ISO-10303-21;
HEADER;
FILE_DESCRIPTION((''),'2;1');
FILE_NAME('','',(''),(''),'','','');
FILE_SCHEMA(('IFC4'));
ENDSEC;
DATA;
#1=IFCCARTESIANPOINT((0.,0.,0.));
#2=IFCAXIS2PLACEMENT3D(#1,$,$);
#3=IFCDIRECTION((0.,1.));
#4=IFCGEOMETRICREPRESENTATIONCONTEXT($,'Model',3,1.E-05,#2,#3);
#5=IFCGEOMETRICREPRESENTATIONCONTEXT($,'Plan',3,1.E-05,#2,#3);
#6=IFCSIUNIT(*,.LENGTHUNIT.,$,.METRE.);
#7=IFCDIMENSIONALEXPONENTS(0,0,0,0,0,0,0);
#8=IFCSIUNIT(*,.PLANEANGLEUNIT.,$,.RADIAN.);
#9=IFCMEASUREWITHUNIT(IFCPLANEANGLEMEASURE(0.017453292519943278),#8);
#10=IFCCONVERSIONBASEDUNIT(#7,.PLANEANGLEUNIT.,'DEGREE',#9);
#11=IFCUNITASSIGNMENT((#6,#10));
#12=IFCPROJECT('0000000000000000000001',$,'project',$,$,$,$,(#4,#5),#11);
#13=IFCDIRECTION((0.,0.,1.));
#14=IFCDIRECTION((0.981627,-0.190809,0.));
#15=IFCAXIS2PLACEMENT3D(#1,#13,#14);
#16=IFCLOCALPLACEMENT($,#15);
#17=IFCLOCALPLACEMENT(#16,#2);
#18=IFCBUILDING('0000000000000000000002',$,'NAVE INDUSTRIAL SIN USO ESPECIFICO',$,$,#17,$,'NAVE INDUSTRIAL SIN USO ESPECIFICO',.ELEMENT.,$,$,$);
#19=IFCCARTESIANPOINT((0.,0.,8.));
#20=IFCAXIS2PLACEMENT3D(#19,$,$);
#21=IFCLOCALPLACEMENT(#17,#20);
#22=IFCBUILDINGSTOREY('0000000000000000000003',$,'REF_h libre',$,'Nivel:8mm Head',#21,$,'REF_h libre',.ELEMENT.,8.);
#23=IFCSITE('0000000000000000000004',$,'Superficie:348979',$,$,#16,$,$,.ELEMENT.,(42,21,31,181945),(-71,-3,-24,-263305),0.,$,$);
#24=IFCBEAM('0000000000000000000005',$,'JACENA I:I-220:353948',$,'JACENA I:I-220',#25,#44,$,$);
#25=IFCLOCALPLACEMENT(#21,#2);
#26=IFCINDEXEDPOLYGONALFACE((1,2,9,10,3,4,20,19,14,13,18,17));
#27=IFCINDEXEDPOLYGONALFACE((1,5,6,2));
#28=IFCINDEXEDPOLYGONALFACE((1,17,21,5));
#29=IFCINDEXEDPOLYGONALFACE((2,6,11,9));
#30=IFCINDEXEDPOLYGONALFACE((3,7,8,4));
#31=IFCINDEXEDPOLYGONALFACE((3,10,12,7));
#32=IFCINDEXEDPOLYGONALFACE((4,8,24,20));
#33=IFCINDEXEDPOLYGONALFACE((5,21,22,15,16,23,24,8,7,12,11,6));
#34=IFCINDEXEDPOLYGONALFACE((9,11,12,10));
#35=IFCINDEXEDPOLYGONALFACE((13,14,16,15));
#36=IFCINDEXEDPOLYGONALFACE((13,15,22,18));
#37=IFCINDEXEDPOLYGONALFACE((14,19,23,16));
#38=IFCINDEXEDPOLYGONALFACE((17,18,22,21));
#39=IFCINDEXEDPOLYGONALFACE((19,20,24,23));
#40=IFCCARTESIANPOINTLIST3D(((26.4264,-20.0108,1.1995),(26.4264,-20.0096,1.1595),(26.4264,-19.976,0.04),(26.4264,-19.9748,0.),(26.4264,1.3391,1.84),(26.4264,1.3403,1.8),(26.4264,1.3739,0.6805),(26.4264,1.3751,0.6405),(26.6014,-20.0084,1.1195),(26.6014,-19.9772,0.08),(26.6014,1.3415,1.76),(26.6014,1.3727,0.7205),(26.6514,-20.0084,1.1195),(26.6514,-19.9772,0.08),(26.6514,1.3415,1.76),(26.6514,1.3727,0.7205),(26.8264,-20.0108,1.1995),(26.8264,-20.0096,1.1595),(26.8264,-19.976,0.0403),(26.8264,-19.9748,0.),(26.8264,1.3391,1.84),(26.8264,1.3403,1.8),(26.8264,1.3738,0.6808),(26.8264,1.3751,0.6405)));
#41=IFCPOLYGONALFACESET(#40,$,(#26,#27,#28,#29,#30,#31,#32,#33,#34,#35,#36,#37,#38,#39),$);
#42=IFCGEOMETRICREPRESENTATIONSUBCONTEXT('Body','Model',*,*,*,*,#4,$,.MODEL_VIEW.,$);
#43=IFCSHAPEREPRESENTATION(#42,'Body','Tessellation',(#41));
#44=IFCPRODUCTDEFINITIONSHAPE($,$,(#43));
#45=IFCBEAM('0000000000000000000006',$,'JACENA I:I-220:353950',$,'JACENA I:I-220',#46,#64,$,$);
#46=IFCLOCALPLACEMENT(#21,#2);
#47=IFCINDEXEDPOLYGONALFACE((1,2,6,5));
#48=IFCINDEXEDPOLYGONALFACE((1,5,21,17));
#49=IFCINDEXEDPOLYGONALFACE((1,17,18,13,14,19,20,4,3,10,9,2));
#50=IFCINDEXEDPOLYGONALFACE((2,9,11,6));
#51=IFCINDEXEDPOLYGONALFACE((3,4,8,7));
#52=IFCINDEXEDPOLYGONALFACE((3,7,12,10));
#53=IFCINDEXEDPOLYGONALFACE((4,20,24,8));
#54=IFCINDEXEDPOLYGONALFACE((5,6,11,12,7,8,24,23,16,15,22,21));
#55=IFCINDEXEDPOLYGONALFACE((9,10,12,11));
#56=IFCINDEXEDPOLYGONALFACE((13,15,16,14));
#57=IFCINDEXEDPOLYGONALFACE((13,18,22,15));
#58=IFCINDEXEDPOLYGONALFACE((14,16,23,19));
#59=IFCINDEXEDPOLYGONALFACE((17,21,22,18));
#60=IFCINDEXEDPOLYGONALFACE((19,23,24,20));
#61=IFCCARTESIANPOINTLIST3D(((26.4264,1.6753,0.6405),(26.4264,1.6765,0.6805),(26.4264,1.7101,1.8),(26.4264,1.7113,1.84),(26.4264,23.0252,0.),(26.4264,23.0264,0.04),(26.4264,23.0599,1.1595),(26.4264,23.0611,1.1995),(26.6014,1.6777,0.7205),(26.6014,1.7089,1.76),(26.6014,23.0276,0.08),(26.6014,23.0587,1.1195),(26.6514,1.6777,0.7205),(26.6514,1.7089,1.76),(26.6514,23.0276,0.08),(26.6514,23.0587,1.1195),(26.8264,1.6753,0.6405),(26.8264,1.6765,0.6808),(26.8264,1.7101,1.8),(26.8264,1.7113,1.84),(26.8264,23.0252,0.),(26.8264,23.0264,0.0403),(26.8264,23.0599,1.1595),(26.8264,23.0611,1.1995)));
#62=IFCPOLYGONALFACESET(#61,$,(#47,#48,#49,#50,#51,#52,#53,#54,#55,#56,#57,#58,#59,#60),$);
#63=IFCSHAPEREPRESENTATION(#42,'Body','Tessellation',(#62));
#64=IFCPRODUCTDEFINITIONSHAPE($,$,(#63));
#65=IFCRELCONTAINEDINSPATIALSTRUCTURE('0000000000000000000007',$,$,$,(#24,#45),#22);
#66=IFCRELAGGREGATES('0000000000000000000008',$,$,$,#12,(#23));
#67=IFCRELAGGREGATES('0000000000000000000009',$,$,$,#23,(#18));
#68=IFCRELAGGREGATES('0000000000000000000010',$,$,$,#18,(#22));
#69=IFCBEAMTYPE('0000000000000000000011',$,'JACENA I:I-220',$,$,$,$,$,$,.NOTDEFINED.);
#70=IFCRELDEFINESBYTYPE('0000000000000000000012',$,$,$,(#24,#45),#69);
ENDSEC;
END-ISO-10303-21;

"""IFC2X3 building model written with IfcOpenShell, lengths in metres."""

from ifc_helpers import new_model, entity, si_unit, converted_unit, direction, frame, origin, place, context, subcontext, project, spatial, polyline, outline, extrude, type_object, element, save


model = new_model("IFC2X3")

# Units and contexts
model_context = context("Model", 3, precision=1e-05, world=origin(), true_north=direction((0.0, 1.0)))
plan_context = context("Plan", 3, precision=1e-05, world=origin(), true_north=direction((0.0, 1.0)))
body_context = subcontext(model_context, "Body", "Model", "MODEL_VIEW")
ifc_project = project(units=[si_unit("LENGTHUNIT", "METRE"), converted_unit("PLANEANGLEUNIT", "DEGREE", entity("IfcPlaneAngleMeasure", 0.017453292519943278), si_unit("PLANEANGLEUNIT", "RADIAN"), dimensions=[0, 0, 0, 0, 0, 0, 0])], contexts=[model_context, plan_context])

# Site, building, storey
site_placement = place(None, frame((0.0, 0.0, 0.0), z_axis=(0.0, 0.0, 1.0), x_axis=(0.981627, -0.190809, 0.0)))
site = spatial("IfcSite", under=ifc_project, at=site_placement, Name="Superficie:348979", CompositionType="ELEMENT", RefLatitude=(42, 21, 31, 181945), RefLongitude=(-71, -3, -24, -263305), RefElevation=0.0)
building_placement = place(site_placement, origin())
building = spatial("IfcBuilding", under=site, at=building_placement, Name="NAVE INDUSTRIAL SIN USO ESPECIFICO", LongName="NAVE INDUSTRIAL SIN USO ESPECIFICO", CompositionType="ELEMENT")
storey_placement = place(building_placement, frame((0.0, 0.0, 8.0)))
storey = spatial("IfcBuildingStorey", under=building, at=storey_placement, Name="REF_h libre", ObjectType="Nivel:8mm Head", LongName="REF_h libre", CompositionType="ELEMENT", Elevation=8.0)

# Beams
beam_type = type_object("IfcBeamType", Name="JACENA I:I-220", PredefinedType="NOTDEFINED")
beam_1_placement = place(storey_placement, frame((26.6264, -19.9748, 0.0), z_axis=(0.0, -0.029987, 0.99955), x_axis=(0.0, 0.99955, 0.029987)))
element("IfcBeam", 1, at=beam_1_placement, inside=storey, type_object=beam_type, Name="JACENA I:I-220:353948", ObjectType="JACENA I:I-220", context=body_context, shape_type="SweptSolid", body=[
    extrude(outline(polyline([(-0.6, -0.2), (-0.56, -0.2), (-0.52, -0.025), (0.52, -0.025), (0.5597, -0.2), (0.6, -0.2), (0.6, 0.2), (0.56, 0.2), (0.52, 0.025), (-0.52, 0.025), (-0.56, 0.2), (-0.6, 0.2), (-0.6, -0.2)])), frame((0.0, 0.0, 0.6), z_axis=(1.0, 0.0, 0.0), x_axis=(0.0, 0.0, -1.0)), (0.0, 0.0, 1.0), 21.3595),
])
beam_2_placement = place(storey_placement, frame((26.6264, 23.0252, 0.0), z_axis=(0.0, 0.029987, 0.99955), x_axis=(0.0, -0.99955, 0.029987)))
element("IfcBeam", 2, at=beam_2_placement, inside=storey, type_object=beam_type, Name="JACENA I:I-220:353950", ObjectType="JACENA I:I-220", context=body_context, shape_type="SweptSolid", body=[
    extrude(outline(polyline([(-0.6, -0.2), (-0.56, -0.2), (-0.52, -0.025), (0.52, -0.025), (0.56, -0.2), (0.6, -0.2), (0.6, 0.2), (0.5597, 0.2), (0.52, 0.025), (-0.52, 0.025), (-0.56, 0.2), (-0.6, 0.2), (-0.6, -0.2)])), frame((0.0, 0.0, 0.6), z_axis=(1.0, 0.0, 0.0), x_axis=(0.0, 0.0, -1.0)), (0.0, 0.0, 1.0), 21.3595),
])

save(model, "model.ifc")
